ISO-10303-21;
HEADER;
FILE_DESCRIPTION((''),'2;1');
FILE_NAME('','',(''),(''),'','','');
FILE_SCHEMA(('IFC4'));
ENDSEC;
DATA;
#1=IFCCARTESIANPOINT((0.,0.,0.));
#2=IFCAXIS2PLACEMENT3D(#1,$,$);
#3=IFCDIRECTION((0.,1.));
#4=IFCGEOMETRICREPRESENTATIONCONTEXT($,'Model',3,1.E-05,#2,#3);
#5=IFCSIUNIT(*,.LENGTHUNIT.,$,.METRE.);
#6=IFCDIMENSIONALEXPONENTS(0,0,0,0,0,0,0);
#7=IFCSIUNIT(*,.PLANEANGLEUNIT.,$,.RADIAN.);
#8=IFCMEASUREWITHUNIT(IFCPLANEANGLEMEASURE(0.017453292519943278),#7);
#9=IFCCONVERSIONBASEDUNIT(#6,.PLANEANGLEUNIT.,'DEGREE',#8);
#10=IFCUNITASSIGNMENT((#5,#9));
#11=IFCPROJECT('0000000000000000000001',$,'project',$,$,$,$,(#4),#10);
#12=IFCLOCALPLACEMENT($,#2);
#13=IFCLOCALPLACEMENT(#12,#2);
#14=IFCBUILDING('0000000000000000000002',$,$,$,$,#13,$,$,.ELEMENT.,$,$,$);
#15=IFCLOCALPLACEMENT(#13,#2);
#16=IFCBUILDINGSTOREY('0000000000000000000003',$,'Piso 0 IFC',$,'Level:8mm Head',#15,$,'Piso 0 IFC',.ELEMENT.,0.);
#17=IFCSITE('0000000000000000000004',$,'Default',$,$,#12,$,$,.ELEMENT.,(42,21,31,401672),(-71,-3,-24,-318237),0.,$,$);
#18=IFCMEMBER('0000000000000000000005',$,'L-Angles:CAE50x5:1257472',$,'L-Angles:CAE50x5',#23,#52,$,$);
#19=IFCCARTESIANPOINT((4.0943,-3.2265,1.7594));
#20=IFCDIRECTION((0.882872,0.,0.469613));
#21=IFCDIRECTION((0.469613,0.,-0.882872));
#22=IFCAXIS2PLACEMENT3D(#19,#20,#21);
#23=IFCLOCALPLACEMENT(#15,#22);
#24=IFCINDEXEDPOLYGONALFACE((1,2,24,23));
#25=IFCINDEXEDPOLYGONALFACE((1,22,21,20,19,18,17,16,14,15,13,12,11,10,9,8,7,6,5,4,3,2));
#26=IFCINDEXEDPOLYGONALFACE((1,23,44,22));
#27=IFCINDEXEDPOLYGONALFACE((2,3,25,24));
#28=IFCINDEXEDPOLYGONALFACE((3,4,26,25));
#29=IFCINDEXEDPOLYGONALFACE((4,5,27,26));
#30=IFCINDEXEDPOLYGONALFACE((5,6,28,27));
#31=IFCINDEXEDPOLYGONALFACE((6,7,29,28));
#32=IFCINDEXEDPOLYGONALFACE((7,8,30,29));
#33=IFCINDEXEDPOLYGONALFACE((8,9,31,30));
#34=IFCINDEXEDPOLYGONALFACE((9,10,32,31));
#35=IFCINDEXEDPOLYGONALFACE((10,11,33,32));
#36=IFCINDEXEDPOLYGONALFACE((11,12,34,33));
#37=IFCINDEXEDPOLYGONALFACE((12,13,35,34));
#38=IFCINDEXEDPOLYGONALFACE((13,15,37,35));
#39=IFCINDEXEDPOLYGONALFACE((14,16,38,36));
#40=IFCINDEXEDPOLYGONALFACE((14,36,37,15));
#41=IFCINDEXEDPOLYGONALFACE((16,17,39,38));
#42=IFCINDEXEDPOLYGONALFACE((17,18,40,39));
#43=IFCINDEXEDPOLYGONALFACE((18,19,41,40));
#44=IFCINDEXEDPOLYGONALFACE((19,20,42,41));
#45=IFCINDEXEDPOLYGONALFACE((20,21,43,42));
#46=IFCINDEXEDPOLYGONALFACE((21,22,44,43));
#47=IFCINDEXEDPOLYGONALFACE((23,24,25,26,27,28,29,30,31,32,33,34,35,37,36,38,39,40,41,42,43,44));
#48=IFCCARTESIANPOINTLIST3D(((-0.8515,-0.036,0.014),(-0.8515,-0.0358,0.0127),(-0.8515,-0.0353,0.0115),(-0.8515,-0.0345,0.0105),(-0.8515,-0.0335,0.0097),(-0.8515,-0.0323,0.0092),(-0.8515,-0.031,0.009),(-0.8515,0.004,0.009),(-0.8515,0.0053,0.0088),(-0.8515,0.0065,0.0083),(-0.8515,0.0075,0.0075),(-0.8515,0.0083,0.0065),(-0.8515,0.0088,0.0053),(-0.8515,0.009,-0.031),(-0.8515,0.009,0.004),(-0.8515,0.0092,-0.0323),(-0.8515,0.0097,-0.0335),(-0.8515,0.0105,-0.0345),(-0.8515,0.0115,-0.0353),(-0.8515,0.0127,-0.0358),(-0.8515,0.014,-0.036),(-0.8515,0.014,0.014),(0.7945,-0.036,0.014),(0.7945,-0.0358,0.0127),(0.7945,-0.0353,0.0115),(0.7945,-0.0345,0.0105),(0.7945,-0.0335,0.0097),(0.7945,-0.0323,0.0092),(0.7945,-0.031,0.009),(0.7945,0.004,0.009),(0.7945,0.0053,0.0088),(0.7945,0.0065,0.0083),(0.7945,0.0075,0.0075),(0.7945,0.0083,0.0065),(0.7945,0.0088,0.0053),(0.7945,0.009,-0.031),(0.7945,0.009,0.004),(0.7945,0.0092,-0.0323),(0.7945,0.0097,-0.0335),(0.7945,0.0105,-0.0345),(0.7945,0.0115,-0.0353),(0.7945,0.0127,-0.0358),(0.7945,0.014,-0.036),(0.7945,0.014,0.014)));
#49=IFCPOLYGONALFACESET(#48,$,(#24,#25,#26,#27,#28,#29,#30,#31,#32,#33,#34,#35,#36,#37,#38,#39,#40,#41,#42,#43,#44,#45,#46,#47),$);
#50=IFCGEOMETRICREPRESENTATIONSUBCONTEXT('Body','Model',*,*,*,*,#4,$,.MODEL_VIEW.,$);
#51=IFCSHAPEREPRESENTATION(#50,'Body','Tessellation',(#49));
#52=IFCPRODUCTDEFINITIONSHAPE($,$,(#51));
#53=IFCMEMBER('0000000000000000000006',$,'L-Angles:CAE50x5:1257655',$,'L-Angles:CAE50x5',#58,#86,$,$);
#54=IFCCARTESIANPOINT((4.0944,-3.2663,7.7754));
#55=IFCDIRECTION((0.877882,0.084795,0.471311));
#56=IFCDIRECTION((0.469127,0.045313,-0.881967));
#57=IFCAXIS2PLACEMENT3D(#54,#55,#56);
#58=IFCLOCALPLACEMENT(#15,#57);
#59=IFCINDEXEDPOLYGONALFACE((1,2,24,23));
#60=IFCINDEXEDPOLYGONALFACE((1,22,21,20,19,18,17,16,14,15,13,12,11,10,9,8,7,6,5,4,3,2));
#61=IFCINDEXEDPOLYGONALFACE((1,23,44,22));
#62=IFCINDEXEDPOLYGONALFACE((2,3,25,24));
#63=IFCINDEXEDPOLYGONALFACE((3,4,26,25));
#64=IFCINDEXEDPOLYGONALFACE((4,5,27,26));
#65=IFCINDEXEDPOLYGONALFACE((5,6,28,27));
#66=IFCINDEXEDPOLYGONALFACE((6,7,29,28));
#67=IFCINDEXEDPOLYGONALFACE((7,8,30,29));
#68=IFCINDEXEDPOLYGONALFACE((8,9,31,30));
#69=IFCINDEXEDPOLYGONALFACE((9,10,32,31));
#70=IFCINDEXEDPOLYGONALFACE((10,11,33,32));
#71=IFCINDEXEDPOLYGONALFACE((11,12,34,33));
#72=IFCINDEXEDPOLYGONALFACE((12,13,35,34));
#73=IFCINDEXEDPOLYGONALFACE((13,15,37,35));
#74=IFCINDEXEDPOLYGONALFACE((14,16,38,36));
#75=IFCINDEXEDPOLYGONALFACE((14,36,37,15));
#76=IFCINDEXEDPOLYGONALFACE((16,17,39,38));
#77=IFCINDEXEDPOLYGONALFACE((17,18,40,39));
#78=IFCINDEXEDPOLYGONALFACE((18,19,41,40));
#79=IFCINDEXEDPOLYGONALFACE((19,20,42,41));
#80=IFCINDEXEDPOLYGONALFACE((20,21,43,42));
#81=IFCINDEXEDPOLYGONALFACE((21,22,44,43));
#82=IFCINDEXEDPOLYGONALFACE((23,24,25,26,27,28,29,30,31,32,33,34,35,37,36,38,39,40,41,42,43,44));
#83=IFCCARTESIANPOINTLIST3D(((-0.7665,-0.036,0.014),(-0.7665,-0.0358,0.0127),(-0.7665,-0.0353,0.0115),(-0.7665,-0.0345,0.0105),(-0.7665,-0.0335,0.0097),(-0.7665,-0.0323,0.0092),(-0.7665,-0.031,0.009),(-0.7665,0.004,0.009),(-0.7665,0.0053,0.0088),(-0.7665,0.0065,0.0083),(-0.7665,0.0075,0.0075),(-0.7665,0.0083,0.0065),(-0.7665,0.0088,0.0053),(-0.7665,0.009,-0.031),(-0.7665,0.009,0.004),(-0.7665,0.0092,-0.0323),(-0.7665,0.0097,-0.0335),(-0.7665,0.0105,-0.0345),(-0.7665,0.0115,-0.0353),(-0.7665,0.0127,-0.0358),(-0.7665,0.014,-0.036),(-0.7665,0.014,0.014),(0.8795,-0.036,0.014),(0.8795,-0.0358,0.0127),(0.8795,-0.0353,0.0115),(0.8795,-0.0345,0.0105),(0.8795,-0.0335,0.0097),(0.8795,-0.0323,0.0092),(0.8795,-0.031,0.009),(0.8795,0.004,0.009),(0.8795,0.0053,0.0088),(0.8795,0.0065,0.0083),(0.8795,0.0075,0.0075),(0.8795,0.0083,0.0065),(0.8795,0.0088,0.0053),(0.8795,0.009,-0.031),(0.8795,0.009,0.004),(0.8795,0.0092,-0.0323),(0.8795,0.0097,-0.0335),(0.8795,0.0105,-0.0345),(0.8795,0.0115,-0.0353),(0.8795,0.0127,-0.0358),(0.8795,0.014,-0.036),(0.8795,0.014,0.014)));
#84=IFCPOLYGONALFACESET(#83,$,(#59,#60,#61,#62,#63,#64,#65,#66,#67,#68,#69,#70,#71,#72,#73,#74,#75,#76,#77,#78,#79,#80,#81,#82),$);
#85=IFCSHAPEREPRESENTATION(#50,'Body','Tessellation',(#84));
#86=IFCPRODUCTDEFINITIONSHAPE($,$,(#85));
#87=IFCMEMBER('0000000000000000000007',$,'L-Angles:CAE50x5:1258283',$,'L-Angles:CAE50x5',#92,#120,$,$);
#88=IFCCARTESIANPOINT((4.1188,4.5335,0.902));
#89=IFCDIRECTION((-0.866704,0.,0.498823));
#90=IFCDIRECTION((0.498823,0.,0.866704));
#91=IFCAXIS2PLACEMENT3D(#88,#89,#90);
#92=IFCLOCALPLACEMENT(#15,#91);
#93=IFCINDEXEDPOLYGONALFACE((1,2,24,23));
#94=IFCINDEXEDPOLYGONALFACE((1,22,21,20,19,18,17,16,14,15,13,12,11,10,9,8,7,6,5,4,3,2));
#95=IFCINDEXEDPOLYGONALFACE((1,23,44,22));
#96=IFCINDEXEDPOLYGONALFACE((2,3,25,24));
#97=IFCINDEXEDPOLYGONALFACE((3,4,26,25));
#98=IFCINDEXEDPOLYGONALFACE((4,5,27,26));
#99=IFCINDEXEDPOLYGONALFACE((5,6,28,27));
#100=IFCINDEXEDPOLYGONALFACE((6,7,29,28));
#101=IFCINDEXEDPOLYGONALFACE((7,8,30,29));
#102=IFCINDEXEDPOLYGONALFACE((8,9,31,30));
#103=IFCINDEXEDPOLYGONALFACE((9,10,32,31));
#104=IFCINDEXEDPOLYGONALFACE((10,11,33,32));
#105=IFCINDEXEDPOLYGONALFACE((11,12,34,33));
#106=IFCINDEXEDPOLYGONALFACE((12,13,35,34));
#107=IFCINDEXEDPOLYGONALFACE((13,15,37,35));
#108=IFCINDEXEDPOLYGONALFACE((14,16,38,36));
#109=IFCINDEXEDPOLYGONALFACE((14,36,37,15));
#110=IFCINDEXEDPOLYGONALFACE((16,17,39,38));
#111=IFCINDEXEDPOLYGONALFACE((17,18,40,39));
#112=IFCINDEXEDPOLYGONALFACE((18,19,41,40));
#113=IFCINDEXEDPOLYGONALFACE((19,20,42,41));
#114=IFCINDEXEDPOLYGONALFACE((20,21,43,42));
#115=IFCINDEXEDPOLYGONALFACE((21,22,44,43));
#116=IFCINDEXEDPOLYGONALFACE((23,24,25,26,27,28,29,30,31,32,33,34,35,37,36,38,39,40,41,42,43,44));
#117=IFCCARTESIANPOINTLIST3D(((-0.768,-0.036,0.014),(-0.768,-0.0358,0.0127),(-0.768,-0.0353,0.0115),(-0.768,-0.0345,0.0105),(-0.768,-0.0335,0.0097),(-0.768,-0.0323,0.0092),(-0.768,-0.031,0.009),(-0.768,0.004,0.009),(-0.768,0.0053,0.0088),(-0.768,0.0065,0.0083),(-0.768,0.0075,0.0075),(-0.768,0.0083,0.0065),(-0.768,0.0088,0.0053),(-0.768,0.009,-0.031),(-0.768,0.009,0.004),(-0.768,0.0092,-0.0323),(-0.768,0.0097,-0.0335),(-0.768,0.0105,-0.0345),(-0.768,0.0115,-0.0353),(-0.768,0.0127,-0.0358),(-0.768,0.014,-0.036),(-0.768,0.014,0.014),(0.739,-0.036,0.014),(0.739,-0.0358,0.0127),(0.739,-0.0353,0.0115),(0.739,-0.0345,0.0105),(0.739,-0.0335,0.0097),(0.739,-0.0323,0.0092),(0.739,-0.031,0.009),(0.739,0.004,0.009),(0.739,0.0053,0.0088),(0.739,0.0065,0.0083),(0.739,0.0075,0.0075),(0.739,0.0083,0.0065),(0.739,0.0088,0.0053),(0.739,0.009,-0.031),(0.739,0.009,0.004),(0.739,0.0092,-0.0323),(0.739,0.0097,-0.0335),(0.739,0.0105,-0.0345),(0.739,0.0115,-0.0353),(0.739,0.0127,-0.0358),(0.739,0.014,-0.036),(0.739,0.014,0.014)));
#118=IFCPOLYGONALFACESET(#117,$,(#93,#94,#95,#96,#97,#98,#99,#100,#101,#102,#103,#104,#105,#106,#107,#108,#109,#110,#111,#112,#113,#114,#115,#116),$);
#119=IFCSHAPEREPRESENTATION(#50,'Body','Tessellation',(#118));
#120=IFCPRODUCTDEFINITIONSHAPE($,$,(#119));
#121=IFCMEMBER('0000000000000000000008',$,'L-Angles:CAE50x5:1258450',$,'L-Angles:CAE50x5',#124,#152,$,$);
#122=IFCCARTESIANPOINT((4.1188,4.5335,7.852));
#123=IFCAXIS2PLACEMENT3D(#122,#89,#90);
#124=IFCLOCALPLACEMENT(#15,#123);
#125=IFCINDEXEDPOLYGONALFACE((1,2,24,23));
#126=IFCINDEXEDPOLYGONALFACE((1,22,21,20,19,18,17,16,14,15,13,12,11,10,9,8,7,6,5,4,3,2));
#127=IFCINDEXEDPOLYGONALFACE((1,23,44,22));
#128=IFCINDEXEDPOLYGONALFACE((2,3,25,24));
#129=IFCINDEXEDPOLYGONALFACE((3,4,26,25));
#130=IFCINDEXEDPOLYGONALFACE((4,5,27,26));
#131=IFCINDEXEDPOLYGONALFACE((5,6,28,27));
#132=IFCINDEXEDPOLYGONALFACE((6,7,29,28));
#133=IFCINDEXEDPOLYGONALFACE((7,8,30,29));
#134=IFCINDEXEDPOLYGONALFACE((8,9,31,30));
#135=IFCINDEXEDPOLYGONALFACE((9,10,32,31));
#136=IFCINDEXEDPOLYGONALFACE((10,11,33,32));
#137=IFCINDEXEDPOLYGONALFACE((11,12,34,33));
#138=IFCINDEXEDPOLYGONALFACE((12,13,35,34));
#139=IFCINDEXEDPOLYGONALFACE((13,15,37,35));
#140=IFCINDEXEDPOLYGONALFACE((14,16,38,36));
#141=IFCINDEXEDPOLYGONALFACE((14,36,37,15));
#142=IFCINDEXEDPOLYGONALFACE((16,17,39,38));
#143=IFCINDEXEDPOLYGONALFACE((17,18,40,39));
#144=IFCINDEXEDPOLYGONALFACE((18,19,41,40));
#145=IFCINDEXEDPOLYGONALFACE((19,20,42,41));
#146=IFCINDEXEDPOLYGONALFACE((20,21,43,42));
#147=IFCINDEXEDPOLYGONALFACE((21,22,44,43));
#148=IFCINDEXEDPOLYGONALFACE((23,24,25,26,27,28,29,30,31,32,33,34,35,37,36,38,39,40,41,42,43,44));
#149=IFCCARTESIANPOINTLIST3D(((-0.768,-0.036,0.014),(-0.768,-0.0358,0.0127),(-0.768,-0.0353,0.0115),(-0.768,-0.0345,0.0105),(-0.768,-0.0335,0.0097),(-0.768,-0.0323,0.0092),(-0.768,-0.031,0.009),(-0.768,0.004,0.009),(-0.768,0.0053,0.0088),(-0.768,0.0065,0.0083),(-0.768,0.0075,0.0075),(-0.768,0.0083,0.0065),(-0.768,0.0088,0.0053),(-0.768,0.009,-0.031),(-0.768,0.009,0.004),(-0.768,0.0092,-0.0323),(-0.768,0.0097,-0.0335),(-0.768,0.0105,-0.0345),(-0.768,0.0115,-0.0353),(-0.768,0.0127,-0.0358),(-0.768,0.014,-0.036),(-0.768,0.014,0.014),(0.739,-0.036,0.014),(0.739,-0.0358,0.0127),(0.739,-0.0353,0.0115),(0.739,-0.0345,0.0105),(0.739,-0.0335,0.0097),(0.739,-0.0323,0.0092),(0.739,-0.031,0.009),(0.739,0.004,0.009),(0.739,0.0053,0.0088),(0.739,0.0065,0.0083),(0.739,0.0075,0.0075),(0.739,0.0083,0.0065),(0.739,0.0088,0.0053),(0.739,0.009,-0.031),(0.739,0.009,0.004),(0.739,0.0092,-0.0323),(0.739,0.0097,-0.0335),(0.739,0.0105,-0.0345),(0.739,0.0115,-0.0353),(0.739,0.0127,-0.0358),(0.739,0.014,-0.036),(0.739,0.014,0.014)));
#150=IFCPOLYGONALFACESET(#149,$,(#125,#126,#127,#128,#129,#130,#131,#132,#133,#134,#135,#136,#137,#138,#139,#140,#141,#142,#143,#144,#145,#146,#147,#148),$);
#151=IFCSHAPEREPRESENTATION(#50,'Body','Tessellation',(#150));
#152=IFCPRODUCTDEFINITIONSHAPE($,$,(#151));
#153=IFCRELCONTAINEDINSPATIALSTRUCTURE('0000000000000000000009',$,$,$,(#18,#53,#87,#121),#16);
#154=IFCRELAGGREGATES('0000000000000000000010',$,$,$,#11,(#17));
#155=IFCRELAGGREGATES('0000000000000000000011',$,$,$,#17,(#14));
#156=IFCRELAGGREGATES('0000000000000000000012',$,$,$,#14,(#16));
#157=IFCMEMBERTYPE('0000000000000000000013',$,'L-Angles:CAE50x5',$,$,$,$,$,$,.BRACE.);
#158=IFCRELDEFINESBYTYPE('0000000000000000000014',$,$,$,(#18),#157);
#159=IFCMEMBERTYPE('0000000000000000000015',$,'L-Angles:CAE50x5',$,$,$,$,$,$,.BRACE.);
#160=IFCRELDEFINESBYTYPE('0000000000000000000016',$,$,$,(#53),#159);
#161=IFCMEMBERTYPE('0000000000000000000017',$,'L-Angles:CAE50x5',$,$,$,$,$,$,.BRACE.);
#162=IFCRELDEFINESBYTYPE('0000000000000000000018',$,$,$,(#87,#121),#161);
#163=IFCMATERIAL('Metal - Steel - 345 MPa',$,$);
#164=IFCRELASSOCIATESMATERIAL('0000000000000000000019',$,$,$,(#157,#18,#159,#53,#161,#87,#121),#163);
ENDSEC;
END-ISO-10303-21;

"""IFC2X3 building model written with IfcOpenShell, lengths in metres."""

from ifc_helpers import new_model, entity, si_unit, converted_unit, direction, frame, frame_2d, origin, place, context, subcontext, project, spatial, polyline, circle_curve, parameter, trimmed, segment, composite_curve, outline, extrude, source, transform, mapped, material, type_object, type_shapes, element, save


model = new_model("IFC2X3")

# Units and contexts
model_context = context("Model", 3, precision=1e-05, world=origin(), true_north=direction((0.0, 1.0)))
body_context = subcontext(model_context, "Body", "Model", "MODEL_VIEW")
ifc_project = project(units=[si_unit("LENGTHUNIT", "METRE"), converted_unit("PLANEANGLEUNIT", "DEGREE", entity("IfcPlaneAngleMeasure", 0.017453292519943278), si_unit("PLANEANGLEUNIT", "RADIAN"), dimensions=[0, 0, 0, 0, 0, 0, 0])], contexts=[model_context])

# Site, building, storey
site_placement = place(None, origin())
site = spatial("IfcSite", under=ifc_project, at=site_placement, Name="Default", CompositionType="ELEMENT", RefLatitude=(42, 21, 31, 401672), RefLongitude=(-71, -3, -24, -318237), RefElevation=0.0)
building_placement = place(site_placement, origin())
building = spatial("IfcBuilding", under=site, at=building_placement, CompositionType="ELEMENT")
storey_placement = place(building_placement, origin())
storey = spatial("IfcBuildingStorey", under=building, at=storey_placement, Name="Piso 0 IFC", ObjectType="Level:8mm Head", LongName="Piso 0 IFC", CompositionType="ELEMENT", Elevation=0.0)

# Shared definitions
ifc_material_1 = material(Name="Metal - Steel - 345 MPa")

# Members
member_type_1 = type_object("IfcMemberType", Name="L-Angles:CAE50x5", PredefinedType="BRACE", material=ifc_material_1)
shared_shape_1 = source(origin(), body_context, "Body", "SweptSolid", [
    extrude(outline(composite_curve([segment(polyline([(-0.0164, -0.0164), (0.0336, -0.0164)]), True, "CONTINUOUS"), segment(trimmed(circle_curve(frame_2d((0.0286, -0.0164), x_axis=(1.0, 0.0)), 0.005), [parameter(0.0)], [parameter(90.0)], True, "PARAMETER"), True, "CONTINUOUS"), segment(polyline([(0.0286, -0.0114), (-0.0064, -0.0114)]), True, "CONTINUOUS"), segment(trimmed(circle_curve(frame_2d((-0.0064, -0.0064), x_axis=(1.0, 0.0)), 0.005), [parameter(180.0)], [parameter(270.0)], True, "PARAMETER"), False, "CONTINUOUS"), segment(polyline([(-0.0114, -0.0064), (-0.0114, 0.0286)]), True, "CONTINUOUS"), segment(trimmed(circle_curve(frame_2d((-0.0164, 0.0286), x_axis=(1.0, 0.0)), 0.005), [parameter(0.0)], [parameter(90.0)], True, "PARAMETER"), True, "CONTINUOUS"), segment(polyline([(-0.0164, 0.0336), (-0.0164, -0.0164)]), True, "CONTINUOUS")], self_intersect=False)), frame((-0.8515, -0.0024, -0.0024), z_axis=(1.0, 0.0, 0.0), x_axis=(0.0, -1.0, 0.0)), (0.0, 0.0, 1.0), 1.646),
])
type_shapes(member_type_1, [shared_shape_1])
member_1_placement = place(storey_placement, frame((4.0943, -3.2265, 1.7594), z_axis=(0.882872, 0.0, 0.469613), x_axis=(0.469613, 0.0, -0.882872)))
element("IfcMember", 1, at=member_1_placement, inside=storey, type_object=member_type_1, material=ifc_material_1, Name="L-Angles:CAE50x5:1257472", ObjectType="L-Angles:CAE50x5", context=body_context, shape_type="MappedRepresentation", body=[
    mapped(shared_shape_1, transform((0.0, 0.0, 0.0), scale=1.0)),
])
member_type_2 = type_object("IfcMemberType", Name="L-Angles:CAE50x5", PredefinedType="BRACE", material=ifc_material_1)
shared_shape_2 = source(origin(), body_context, "Body", "SweptSolid", [
    extrude(outline(composite_curve([segment(polyline([(-0.0164, -0.0164), (0.0336, -0.0164)]), True, "CONTINUOUS"), segment(trimmed(circle_curve(frame_2d((0.0286, -0.0164), x_axis=(1.0, 0.0)), 0.005), [parameter(0.0)], [parameter(90.0)], True, "PARAMETER"), True, "CONTINUOUS"), segment(polyline([(0.0286, -0.0114), (-0.0064, -0.0114)]), True, "CONTINUOUS"), segment(trimmed(circle_curve(frame_2d((-0.0064, -0.0064), x_axis=(1.0, 0.0)), 0.005), [parameter(180.0)], [parameter(270.0)], True, "PARAMETER"), False, "CONTINUOUS"), segment(polyline([(-0.0114, -0.0064), (-0.0114, 0.0286)]), True, "CONTINUOUS"), segment(trimmed(circle_curve(frame_2d((-0.0164, 0.0286), x_axis=(1.0, 0.0)), 0.005), [parameter(0.0)], [parameter(90.0)], True, "PARAMETER"), True, "CONTINUOUS"), segment(polyline([(-0.0164, 0.0336), (-0.0164, -0.0164)]), True, "CONTINUOUS")], self_intersect=False)), frame((-0.7665, -0.0024, -0.0024), z_axis=(1.0, 0.0, 0.0), x_axis=(0.0, -1.0, 0.0)), (0.0, 0.0, 1.0), 1.646),
])
type_shapes(member_type_2, [shared_shape_2])
member_2_placement = place(storey_placement, frame((4.0944, -3.2663, 7.7754), z_axis=(0.877882, 0.084795, 0.471311), x_axis=(0.469127, 0.045313, -0.881967)))
element("IfcMember", 2, at=member_2_placement, inside=storey, type_object=member_type_2, material=ifc_material_1, Name="L-Angles:CAE50x5:1257655", ObjectType="L-Angles:CAE50x5", context=body_context, shape_type="MappedRepresentation", body=[
    mapped(shared_shape_2, transform((0.0, 0.0, 0.0), scale=1.0)),
])
member_type_3 = type_object("IfcMemberType", Name="L-Angles:CAE50x5", PredefinedType="BRACE", material=ifc_material_1)
shared_shape_3 = source(origin(), body_context, "Body", "SweptSolid", [
    extrude(outline(composite_curve([segment(polyline([(-0.0164, -0.0164), (0.0336, -0.0164)]), True, "CONTINUOUS"), segment(trimmed(circle_curve(frame_2d((0.0286, -0.0164), x_axis=(1.0, 0.0)), 0.005), [parameter(0.0)], [parameter(90.0)], True, "PARAMETER"), True, "CONTINUOUS"), segment(polyline([(0.0286, -0.0114), (-0.0064, -0.0114)]), True, "CONTINUOUS"), segment(trimmed(circle_curve(frame_2d((-0.0064, -0.0064), x_axis=(1.0, 0.0)), 0.005), [parameter(180.0)], [parameter(270.0)], True, "PARAMETER"), False, "CONTINUOUS"), segment(polyline([(-0.0114, -0.0064), (-0.0114, 0.0286)]), True, "CONTINUOUS"), segment(trimmed(circle_curve(frame_2d((-0.0164, 0.0286), x_axis=(1.0, 0.0)), 0.005), [parameter(0.0)], [parameter(90.0)], True, "PARAMETER"), True, "CONTINUOUS"), segment(polyline([(-0.0164, 0.0336), (-0.0164, -0.0164)]), True, "CONTINUOUS")], self_intersect=False)), frame((-0.768, -0.0024, -0.0024), z_axis=(1.0, 0.0, 0.0), x_axis=(0.0, -1.0, 0.0)), (0.0, 0.0, 1.0), 1.507),
])
type_shapes(member_type_3, [shared_shape_3])
for number, where, z_axis, x_axis, name in (
    (3, (4.1188, 4.5335, 0.902), (-0.866704, 0.0, 0.498823), (0.498823, 0.0, 0.866704), "L-Angles:CAE50x5:1258283"),
    (4, (4.1188, 4.5335, 7.852), (-0.866704, 0.0, 0.498823), (0.498823, 0.0, 0.866704), "L-Angles:CAE50x5:1258450"),
):
    element("IfcMember", number, at=place(storey_placement, frame(where, z_axis=z_axis, x_axis=x_axis)), inside=storey, type_object=member_type_3, material=ifc_material_1, Name=name, ObjectType="L-Angles:CAE50x5", context=body_context, shape_type="MappedRepresentation", body=[
        mapped(shared_shape_3, transform((0.0, 0.0, 0.0), scale=1.0)),
    ])

save(model, "model.ifc")
